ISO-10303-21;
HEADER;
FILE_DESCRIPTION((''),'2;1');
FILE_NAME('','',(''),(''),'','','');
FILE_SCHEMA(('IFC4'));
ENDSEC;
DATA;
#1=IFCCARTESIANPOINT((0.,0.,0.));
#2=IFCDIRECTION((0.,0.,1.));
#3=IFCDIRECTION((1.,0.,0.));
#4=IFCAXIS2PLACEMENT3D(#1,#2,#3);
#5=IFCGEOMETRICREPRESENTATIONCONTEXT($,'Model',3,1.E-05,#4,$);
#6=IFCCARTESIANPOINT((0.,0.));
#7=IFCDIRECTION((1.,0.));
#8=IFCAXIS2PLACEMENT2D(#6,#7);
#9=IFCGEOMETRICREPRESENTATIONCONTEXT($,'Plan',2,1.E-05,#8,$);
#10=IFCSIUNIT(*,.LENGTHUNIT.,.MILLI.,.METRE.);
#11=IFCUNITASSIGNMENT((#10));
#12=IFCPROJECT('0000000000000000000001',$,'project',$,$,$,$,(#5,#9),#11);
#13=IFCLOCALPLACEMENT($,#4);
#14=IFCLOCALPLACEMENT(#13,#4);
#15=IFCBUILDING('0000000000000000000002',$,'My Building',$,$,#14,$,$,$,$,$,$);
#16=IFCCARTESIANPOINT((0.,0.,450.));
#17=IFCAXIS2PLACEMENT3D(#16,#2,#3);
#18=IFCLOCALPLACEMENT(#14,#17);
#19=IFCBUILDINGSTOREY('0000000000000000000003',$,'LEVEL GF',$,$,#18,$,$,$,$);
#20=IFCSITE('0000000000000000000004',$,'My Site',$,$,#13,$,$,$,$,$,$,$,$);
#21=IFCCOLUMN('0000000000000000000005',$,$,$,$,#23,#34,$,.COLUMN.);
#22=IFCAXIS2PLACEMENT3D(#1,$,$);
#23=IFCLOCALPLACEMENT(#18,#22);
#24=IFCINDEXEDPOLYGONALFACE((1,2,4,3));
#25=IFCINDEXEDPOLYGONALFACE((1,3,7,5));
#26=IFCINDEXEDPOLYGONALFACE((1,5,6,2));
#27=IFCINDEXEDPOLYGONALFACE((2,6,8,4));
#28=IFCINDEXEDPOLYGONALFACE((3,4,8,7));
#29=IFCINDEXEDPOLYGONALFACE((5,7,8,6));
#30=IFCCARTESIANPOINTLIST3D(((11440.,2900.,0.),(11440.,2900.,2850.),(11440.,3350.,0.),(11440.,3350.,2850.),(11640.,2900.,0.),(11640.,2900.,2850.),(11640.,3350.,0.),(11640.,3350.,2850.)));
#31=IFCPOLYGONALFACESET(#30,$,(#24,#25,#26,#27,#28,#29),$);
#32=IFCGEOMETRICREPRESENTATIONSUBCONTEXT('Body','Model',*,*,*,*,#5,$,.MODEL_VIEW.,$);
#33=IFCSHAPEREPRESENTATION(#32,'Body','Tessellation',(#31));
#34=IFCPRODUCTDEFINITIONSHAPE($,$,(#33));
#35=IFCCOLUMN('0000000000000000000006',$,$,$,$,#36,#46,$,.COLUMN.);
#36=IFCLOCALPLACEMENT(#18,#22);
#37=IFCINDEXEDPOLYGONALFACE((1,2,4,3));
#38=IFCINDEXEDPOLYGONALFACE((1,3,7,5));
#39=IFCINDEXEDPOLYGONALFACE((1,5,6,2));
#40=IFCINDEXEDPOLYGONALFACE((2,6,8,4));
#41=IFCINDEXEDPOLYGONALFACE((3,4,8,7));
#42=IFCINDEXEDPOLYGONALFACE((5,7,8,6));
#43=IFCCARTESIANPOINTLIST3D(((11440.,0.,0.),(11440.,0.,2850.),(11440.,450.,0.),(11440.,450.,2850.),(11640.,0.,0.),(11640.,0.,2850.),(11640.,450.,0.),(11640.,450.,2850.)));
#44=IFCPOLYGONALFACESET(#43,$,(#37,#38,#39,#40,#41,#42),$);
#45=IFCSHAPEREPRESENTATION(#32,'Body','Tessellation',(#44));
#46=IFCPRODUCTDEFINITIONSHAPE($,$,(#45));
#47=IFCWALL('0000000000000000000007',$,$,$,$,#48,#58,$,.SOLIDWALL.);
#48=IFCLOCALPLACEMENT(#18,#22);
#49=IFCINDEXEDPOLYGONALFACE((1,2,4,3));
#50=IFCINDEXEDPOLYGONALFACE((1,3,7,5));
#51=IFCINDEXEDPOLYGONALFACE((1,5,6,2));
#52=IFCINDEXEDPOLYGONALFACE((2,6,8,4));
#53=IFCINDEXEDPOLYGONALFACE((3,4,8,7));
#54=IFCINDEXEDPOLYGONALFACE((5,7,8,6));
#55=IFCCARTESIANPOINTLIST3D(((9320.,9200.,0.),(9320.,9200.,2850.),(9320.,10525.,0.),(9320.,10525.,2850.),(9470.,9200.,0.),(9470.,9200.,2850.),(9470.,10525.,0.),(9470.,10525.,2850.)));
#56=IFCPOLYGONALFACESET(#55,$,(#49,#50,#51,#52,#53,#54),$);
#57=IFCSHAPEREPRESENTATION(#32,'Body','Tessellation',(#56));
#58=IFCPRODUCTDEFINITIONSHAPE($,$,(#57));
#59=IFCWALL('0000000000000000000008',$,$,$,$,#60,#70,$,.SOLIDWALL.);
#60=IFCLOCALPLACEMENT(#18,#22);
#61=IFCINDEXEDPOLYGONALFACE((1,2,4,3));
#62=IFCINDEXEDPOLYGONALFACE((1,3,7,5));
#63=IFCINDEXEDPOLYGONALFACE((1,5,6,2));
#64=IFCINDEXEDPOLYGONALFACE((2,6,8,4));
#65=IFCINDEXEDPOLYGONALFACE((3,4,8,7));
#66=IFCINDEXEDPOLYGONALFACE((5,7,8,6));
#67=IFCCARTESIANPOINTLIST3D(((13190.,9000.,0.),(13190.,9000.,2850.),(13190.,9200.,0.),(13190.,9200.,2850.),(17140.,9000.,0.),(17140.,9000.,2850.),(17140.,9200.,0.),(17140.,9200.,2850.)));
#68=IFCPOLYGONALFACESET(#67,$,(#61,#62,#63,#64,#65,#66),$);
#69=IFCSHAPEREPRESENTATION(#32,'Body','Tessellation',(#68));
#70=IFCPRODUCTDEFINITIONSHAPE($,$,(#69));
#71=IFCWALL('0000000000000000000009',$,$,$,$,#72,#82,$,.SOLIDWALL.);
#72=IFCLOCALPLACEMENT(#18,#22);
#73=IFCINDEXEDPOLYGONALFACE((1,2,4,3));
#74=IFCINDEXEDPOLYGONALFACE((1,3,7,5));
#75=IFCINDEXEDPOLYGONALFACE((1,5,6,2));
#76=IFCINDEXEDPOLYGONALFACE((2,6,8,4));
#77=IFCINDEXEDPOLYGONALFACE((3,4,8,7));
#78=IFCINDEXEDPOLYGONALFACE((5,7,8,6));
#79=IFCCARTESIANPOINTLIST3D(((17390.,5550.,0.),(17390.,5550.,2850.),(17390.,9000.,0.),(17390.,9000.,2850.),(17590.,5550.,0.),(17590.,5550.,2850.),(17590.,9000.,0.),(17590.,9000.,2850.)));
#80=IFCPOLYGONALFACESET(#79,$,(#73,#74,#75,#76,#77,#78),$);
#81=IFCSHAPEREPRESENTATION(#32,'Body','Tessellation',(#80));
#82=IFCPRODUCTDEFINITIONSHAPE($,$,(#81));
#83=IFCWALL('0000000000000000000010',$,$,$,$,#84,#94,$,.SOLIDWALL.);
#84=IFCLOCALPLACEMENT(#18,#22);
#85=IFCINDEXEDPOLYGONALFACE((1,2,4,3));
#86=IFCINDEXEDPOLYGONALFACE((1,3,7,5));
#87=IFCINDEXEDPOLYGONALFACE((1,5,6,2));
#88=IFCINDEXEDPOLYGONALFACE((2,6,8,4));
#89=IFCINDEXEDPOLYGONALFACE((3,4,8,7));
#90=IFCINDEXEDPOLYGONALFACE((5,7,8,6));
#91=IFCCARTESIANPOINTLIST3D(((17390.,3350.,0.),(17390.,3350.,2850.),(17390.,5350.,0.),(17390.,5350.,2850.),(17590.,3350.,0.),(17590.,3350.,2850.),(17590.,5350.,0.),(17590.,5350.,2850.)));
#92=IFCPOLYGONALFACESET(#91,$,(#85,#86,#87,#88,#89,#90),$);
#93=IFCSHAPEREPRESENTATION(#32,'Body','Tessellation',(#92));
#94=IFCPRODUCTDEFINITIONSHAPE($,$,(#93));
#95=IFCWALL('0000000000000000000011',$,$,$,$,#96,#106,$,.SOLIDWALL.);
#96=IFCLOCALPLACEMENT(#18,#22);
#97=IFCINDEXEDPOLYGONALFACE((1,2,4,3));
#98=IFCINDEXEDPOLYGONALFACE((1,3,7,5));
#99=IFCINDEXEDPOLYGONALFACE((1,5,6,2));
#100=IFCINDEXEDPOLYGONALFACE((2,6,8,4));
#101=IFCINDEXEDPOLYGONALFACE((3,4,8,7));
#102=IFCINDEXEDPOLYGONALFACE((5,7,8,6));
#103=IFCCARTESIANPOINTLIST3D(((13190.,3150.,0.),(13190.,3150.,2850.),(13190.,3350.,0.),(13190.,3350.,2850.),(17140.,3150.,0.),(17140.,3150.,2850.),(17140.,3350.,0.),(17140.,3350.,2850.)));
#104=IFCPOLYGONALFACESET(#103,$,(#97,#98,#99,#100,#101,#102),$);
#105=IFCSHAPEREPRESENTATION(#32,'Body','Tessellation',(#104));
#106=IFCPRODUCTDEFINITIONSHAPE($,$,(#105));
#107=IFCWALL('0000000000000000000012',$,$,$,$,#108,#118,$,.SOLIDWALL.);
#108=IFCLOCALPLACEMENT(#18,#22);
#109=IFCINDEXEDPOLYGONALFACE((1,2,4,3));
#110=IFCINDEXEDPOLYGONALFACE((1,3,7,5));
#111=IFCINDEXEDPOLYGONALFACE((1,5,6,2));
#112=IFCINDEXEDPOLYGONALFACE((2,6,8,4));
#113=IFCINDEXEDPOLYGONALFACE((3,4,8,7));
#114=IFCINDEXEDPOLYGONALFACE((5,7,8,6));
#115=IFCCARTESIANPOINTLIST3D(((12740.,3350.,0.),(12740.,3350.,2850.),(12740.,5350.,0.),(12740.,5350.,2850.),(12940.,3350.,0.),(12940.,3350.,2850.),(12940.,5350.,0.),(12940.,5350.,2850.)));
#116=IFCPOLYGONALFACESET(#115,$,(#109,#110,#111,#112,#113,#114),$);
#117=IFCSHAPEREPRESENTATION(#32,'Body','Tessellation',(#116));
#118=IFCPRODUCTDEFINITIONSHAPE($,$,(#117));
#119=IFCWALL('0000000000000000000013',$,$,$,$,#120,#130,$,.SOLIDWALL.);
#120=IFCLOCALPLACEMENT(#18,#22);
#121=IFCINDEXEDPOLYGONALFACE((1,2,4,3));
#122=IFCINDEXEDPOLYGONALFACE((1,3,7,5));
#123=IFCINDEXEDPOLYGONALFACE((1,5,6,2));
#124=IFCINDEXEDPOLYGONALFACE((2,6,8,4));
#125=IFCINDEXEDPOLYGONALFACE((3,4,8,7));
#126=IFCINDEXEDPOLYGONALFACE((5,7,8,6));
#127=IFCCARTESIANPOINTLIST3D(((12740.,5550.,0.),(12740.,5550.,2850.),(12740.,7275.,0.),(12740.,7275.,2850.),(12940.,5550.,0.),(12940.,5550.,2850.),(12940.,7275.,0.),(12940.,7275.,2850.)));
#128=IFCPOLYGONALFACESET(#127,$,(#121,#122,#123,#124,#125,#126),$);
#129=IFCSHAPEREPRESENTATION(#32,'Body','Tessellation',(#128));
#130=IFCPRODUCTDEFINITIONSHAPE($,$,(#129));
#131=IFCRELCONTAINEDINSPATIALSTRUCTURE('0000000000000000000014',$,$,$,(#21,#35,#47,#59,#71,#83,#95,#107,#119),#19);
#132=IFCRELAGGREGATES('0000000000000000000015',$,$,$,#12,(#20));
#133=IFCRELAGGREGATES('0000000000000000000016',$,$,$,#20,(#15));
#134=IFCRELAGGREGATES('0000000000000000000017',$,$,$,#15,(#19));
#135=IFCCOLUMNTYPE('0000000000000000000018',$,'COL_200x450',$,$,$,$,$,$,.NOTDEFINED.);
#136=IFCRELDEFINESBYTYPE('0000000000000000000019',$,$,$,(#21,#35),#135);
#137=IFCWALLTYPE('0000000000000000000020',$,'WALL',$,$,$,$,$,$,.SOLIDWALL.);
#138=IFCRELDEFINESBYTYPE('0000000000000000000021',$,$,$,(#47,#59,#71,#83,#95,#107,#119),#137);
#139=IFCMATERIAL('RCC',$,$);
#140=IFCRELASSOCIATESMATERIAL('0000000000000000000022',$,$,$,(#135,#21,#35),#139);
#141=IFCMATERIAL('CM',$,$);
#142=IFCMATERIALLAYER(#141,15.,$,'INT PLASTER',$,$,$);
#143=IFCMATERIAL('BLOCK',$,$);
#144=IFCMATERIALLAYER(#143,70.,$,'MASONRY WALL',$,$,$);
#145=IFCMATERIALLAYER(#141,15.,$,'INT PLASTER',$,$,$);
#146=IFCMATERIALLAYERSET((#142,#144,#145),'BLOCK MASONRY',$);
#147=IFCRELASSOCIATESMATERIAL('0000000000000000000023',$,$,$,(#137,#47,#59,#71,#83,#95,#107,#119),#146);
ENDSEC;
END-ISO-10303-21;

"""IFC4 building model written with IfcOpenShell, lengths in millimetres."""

from ifc_helpers import new_model, si_unit, frame, origin_with_axes, origin_2d_with_axis, place, context, subcontext, project, spatial, indexed_curve, rectangle, outline, extrude, material, layer, layer_set, layer_usage, material_profile, profile_set, profile_usage, type_object, element, save


model = new_model("IFC4")

# Units and contexts
model_context = context("Model", 3, precision=1e-05, world=origin_with_axes())
plan_context = context("Plan", 2, precision=1e-05, world=origin_2d_with_axis())
body_context = subcontext(model_context, "Body", "Model", "MODEL_VIEW")
ifc_project = project(units=[si_unit("LENGTHUNIT", "METRE", prefix="MILLI")], contexts=[model_context, plan_context])

# Site, building, storey
site_placement = place(None, origin_with_axes())
site = spatial("IfcSite", under=ifc_project, at=site_placement, Name="My Site")
building_placement = place(site_placement, origin_with_axes())
building = spatial("IfcBuilding", under=site, at=building_placement, Name="My Building")
storey_placement = place(building_placement, frame((0.0, 0.0, 450.0), z_axis=(0.0, 0.0, 1.0), x_axis=(1.0, 0.0, 0.0)))
storey = spatial("IfcBuildingStorey", under=building, at=storey_placement, Name="LEVEL GF")

# Columns
ifc_material_1 = material(Name="RCC")
ifc_material_profile = material_profile(ifc_material_1, rectangle(XDim=200.0, YDim=450.0))
ifc_profile_set = profile_set([ifc_material_profile], Name="COL_200x450")
column_type = type_object("IfcColumnType", Name="COL_200x450", PredefinedType="NOTDEFINED", material=ifc_profile_set)
ifc_profile_usage_1 = profile_usage(ifc_profile_set)
column_1_placement = place(storey_placement, frame((11540.0, 3125.0, 0.0), z_axis=(0.0, 0.0, 1.0), x_axis=(1.0, 0.0, 0.0)))
element("IfcColumn", 1, at=column_1_placement, inside=storey, type_object=column_type, material=ifc_profile_usage_1, PredefinedType="COLUMN", context=body_context, shape_type="SweptSolid", body=[
    extrude(rectangle(XDim=200.0, YDim=450.0), origin_with_axes(), (0.0, 0.0, 1.0), 2850.0),
])
ifc_profile_usage_2 = profile_usage(ifc_profile_set)
column_2_placement = place(storey_placement, frame((11540.0, 225.0, 0.0), z_axis=(0.0, 0.0, 1.0), x_axis=(1.0, 0.0, 0.0)))
element("IfcColumn", 2, at=column_2_placement, inside=storey, type_object=column_type, material=ifc_profile_usage_2, PredefinedType="COLUMN", context=body_context, shape_type="SweptSolid", body=[
    extrude(rectangle(XDim=200.0, YDim=450.0), origin_with_axes(), (0.0, 0.0, 1.0), 2850.0),
])

# Walls
ifc_material_2 = material(Name="CM")
ifc_layer_1 = layer(ifc_material_2, 15.0, Name="INT PLASTER")
ifc_material_3 = material(Name="BLOCK")
ifc_layer_2 = layer(ifc_material_3, 70.0, Name="MASONRY WALL")
ifc_layer_3 = layer(ifc_material_2, 15.0, Name="INT PLASTER")
ifc_layer_set = layer_set([ifc_layer_1, ifc_layer_2, ifc_layer_3], Name="BLOCK MASONRY")
ifc_layer_usage_1 = layer_usage(ifc_layer_set, "AXIS2", "POSITIVE", 0.0)
wall_type = type_object("IfcWallType", Name="WALL", PredefinedType="SOLIDWALL", material=ifc_layer_set)
wall_1_placement = place(storey_placement, frame((9470.0, 9200.0, 0.0), z_axis=(0.0, 0.0, 1.0), x_axis=(0.0, 1.0, 0.0)))
element("IfcWall", 3, at=wall_1_placement, inside=storey, type_object=wall_type, material=ifc_layer_usage_1, PredefinedType="SOLIDWALL", context=body_context, shape_type="SweptSolid", body=[
    extrude(outline(indexed_curve([(0.0, 0.0), (0.0, 150.0), (1325.0, 150.0), (1325.0, 0.0), (0.0, 0.0)], self_intersect=False)), origin_with_axes(), (0.0, 0.0, 1.0), 2850.0),
])
ifc_layer_usage_2 = layer_usage(ifc_layer_set, "AXIS2", "POSITIVE", 0.0)
wall_2_placement = place(storey_placement, frame((13190.0, 9200.0, 0.0), z_axis=(0.0, 0.0, 1.0), x_axis=(0.0, -1.0, 0.0)))
element("IfcWall", 4, at=wall_2_placement, inside=storey, type_object=wall_type, material=ifc_layer_usage_2, PredefinedType="SOLIDWALL", context=body_context, shape_type="SweptSolid", body=[
    extrude(outline(indexed_curve([(0.0, 0.0), (0.0, 3950.0), (200.0, 3950.0), (200.0, 0.0), (0.0, 0.0)], self_intersect=False)), origin_with_axes(), (0.0, 0.0, 1.0), 2850.0),
])
ifc_layer_usage_3 = layer_usage(ifc_layer_set, "AXIS2", "POSITIVE", 0.0)
wall_3_placement = place(storey_placement, frame((17590.0, 5550.0, 0.0), z_axis=(0.0, 0.0, 1.0), x_axis=(0.0, 1.0, 0.0)))
element("IfcWall", 5, at=wall_3_placement, inside=storey, type_object=wall_type, material=ifc_layer_usage_3, PredefinedType="SOLIDWALL", context=body_context, shape_type="SweptSolid", body=[
    extrude(outline(indexed_curve([(0.0, 0.0), (0.0, 200.0), (3450.0, 200.0), (3450.0, 0.0), (0.0, 0.0)], self_intersect=False)), origin_with_axes(), (0.0, 0.0, 1.0), 2850.0),
])
ifc_layer_usage_4 = layer_usage(ifc_layer_set, "AXIS2", "POSITIVE", 0.0)
wall_4_placement = place(storey_placement, frame((17590.0, 3350.0, 0.0), z_axis=(0.0, 0.0, 1.0), x_axis=(0.0, 1.0, 0.0)))
element("IfcWall", 6, at=wall_4_placement, inside=storey, type_object=wall_type, material=ifc_layer_usage_4, PredefinedType="SOLIDWALL", context=body_context, shape_type="SweptSolid", body=[
    extrude(outline(indexed_curve([(0.0, 0.0), (0.0, 200.0), (2000.0, 200.0), (2000.0, 0.0), (0.0, 0.0)], self_intersect=False)), origin_with_axes(), (0.0, 0.0, 1.0), 2850.0),
])
ifc_layer_usage_5 = layer_usage(ifc_layer_set, "AXIS2", "POSITIVE", 0.0)
wall_5_placement = place(storey_placement, frame((13190.0, 3350.0, 0.0), z_axis=(0.0, 0.0, 1.0), x_axis=(0.0, -1.0, 0.0)))
element("IfcWall", 7, at=wall_5_placement, inside=storey, type_object=wall_type, material=ifc_layer_usage_5, PredefinedType="SOLIDWALL", context=body_context, shape_type="SweptSolid", body=[
    extrude(outline(indexed_curve([(0.0, 0.0), (0.0, 3950.0), (200.0, 3950.0), (200.0, 0.0), (0.0, 0.0)], self_intersect=False)), origin_with_axes(), (0.0, 0.0, 1.0), 2850.0),
])
ifc_layer_usage_6 = layer_usage(ifc_layer_set, "AXIS2", "POSITIVE", 0.0)
wall_6_placement = place(storey_placement, frame((12940.0, 3350.0, 0.0), z_axis=(0.0, 0.0, 1.0), x_axis=(0.0, 1.0, 0.0)))
element("IfcWall", 8, at=wall_6_placement, inside=storey, type_object=wall_type, material=ifc_layer_usage_6, PredefinedType="SOLIDWALL", context=body_context, shape_type="SweptSolid", body=[
    extrude(outline(indexed_curve([(0.0, 0.0), (0.0, 200.0), (2000.0, 200.0), (2000.0, 0.0), (0.0, 0.0)], self_intersect=False)), origin_with_axes(), (0.0, 0.0, 1.0), 2850.0),
])
ifc_layer_usage_7 = layer_usage(ifc_layer_set, "AXIS2", "POSITIVE", 0.0)
wall_7_placement = place(storey_placement, frame((12940.0, 5550.0, 0.0), z_axis=(0.0, 0.0, 1.0), x_axis=(0.0, 1.0, 0.0)))
element("IfcWall", 9, at=wall_7_placement, inside=storey, type_object=wall_type, material=ifc_layer_usage_7, PredefinedType="SOLIDWALL", context=body_context, shape_type="SweptSolid", body=[
    extrude(outline(indexed_curve([(0.0, 0.0), (0.0, 200.0), (1725.0, 200.0), (1725.0, 0.0), (0.0, 0.0)], self_intersect=False)), origin_with_axes(), (0.0, 0.0, 1.0), 2850.0),
])

save(model, "model.ifc")
